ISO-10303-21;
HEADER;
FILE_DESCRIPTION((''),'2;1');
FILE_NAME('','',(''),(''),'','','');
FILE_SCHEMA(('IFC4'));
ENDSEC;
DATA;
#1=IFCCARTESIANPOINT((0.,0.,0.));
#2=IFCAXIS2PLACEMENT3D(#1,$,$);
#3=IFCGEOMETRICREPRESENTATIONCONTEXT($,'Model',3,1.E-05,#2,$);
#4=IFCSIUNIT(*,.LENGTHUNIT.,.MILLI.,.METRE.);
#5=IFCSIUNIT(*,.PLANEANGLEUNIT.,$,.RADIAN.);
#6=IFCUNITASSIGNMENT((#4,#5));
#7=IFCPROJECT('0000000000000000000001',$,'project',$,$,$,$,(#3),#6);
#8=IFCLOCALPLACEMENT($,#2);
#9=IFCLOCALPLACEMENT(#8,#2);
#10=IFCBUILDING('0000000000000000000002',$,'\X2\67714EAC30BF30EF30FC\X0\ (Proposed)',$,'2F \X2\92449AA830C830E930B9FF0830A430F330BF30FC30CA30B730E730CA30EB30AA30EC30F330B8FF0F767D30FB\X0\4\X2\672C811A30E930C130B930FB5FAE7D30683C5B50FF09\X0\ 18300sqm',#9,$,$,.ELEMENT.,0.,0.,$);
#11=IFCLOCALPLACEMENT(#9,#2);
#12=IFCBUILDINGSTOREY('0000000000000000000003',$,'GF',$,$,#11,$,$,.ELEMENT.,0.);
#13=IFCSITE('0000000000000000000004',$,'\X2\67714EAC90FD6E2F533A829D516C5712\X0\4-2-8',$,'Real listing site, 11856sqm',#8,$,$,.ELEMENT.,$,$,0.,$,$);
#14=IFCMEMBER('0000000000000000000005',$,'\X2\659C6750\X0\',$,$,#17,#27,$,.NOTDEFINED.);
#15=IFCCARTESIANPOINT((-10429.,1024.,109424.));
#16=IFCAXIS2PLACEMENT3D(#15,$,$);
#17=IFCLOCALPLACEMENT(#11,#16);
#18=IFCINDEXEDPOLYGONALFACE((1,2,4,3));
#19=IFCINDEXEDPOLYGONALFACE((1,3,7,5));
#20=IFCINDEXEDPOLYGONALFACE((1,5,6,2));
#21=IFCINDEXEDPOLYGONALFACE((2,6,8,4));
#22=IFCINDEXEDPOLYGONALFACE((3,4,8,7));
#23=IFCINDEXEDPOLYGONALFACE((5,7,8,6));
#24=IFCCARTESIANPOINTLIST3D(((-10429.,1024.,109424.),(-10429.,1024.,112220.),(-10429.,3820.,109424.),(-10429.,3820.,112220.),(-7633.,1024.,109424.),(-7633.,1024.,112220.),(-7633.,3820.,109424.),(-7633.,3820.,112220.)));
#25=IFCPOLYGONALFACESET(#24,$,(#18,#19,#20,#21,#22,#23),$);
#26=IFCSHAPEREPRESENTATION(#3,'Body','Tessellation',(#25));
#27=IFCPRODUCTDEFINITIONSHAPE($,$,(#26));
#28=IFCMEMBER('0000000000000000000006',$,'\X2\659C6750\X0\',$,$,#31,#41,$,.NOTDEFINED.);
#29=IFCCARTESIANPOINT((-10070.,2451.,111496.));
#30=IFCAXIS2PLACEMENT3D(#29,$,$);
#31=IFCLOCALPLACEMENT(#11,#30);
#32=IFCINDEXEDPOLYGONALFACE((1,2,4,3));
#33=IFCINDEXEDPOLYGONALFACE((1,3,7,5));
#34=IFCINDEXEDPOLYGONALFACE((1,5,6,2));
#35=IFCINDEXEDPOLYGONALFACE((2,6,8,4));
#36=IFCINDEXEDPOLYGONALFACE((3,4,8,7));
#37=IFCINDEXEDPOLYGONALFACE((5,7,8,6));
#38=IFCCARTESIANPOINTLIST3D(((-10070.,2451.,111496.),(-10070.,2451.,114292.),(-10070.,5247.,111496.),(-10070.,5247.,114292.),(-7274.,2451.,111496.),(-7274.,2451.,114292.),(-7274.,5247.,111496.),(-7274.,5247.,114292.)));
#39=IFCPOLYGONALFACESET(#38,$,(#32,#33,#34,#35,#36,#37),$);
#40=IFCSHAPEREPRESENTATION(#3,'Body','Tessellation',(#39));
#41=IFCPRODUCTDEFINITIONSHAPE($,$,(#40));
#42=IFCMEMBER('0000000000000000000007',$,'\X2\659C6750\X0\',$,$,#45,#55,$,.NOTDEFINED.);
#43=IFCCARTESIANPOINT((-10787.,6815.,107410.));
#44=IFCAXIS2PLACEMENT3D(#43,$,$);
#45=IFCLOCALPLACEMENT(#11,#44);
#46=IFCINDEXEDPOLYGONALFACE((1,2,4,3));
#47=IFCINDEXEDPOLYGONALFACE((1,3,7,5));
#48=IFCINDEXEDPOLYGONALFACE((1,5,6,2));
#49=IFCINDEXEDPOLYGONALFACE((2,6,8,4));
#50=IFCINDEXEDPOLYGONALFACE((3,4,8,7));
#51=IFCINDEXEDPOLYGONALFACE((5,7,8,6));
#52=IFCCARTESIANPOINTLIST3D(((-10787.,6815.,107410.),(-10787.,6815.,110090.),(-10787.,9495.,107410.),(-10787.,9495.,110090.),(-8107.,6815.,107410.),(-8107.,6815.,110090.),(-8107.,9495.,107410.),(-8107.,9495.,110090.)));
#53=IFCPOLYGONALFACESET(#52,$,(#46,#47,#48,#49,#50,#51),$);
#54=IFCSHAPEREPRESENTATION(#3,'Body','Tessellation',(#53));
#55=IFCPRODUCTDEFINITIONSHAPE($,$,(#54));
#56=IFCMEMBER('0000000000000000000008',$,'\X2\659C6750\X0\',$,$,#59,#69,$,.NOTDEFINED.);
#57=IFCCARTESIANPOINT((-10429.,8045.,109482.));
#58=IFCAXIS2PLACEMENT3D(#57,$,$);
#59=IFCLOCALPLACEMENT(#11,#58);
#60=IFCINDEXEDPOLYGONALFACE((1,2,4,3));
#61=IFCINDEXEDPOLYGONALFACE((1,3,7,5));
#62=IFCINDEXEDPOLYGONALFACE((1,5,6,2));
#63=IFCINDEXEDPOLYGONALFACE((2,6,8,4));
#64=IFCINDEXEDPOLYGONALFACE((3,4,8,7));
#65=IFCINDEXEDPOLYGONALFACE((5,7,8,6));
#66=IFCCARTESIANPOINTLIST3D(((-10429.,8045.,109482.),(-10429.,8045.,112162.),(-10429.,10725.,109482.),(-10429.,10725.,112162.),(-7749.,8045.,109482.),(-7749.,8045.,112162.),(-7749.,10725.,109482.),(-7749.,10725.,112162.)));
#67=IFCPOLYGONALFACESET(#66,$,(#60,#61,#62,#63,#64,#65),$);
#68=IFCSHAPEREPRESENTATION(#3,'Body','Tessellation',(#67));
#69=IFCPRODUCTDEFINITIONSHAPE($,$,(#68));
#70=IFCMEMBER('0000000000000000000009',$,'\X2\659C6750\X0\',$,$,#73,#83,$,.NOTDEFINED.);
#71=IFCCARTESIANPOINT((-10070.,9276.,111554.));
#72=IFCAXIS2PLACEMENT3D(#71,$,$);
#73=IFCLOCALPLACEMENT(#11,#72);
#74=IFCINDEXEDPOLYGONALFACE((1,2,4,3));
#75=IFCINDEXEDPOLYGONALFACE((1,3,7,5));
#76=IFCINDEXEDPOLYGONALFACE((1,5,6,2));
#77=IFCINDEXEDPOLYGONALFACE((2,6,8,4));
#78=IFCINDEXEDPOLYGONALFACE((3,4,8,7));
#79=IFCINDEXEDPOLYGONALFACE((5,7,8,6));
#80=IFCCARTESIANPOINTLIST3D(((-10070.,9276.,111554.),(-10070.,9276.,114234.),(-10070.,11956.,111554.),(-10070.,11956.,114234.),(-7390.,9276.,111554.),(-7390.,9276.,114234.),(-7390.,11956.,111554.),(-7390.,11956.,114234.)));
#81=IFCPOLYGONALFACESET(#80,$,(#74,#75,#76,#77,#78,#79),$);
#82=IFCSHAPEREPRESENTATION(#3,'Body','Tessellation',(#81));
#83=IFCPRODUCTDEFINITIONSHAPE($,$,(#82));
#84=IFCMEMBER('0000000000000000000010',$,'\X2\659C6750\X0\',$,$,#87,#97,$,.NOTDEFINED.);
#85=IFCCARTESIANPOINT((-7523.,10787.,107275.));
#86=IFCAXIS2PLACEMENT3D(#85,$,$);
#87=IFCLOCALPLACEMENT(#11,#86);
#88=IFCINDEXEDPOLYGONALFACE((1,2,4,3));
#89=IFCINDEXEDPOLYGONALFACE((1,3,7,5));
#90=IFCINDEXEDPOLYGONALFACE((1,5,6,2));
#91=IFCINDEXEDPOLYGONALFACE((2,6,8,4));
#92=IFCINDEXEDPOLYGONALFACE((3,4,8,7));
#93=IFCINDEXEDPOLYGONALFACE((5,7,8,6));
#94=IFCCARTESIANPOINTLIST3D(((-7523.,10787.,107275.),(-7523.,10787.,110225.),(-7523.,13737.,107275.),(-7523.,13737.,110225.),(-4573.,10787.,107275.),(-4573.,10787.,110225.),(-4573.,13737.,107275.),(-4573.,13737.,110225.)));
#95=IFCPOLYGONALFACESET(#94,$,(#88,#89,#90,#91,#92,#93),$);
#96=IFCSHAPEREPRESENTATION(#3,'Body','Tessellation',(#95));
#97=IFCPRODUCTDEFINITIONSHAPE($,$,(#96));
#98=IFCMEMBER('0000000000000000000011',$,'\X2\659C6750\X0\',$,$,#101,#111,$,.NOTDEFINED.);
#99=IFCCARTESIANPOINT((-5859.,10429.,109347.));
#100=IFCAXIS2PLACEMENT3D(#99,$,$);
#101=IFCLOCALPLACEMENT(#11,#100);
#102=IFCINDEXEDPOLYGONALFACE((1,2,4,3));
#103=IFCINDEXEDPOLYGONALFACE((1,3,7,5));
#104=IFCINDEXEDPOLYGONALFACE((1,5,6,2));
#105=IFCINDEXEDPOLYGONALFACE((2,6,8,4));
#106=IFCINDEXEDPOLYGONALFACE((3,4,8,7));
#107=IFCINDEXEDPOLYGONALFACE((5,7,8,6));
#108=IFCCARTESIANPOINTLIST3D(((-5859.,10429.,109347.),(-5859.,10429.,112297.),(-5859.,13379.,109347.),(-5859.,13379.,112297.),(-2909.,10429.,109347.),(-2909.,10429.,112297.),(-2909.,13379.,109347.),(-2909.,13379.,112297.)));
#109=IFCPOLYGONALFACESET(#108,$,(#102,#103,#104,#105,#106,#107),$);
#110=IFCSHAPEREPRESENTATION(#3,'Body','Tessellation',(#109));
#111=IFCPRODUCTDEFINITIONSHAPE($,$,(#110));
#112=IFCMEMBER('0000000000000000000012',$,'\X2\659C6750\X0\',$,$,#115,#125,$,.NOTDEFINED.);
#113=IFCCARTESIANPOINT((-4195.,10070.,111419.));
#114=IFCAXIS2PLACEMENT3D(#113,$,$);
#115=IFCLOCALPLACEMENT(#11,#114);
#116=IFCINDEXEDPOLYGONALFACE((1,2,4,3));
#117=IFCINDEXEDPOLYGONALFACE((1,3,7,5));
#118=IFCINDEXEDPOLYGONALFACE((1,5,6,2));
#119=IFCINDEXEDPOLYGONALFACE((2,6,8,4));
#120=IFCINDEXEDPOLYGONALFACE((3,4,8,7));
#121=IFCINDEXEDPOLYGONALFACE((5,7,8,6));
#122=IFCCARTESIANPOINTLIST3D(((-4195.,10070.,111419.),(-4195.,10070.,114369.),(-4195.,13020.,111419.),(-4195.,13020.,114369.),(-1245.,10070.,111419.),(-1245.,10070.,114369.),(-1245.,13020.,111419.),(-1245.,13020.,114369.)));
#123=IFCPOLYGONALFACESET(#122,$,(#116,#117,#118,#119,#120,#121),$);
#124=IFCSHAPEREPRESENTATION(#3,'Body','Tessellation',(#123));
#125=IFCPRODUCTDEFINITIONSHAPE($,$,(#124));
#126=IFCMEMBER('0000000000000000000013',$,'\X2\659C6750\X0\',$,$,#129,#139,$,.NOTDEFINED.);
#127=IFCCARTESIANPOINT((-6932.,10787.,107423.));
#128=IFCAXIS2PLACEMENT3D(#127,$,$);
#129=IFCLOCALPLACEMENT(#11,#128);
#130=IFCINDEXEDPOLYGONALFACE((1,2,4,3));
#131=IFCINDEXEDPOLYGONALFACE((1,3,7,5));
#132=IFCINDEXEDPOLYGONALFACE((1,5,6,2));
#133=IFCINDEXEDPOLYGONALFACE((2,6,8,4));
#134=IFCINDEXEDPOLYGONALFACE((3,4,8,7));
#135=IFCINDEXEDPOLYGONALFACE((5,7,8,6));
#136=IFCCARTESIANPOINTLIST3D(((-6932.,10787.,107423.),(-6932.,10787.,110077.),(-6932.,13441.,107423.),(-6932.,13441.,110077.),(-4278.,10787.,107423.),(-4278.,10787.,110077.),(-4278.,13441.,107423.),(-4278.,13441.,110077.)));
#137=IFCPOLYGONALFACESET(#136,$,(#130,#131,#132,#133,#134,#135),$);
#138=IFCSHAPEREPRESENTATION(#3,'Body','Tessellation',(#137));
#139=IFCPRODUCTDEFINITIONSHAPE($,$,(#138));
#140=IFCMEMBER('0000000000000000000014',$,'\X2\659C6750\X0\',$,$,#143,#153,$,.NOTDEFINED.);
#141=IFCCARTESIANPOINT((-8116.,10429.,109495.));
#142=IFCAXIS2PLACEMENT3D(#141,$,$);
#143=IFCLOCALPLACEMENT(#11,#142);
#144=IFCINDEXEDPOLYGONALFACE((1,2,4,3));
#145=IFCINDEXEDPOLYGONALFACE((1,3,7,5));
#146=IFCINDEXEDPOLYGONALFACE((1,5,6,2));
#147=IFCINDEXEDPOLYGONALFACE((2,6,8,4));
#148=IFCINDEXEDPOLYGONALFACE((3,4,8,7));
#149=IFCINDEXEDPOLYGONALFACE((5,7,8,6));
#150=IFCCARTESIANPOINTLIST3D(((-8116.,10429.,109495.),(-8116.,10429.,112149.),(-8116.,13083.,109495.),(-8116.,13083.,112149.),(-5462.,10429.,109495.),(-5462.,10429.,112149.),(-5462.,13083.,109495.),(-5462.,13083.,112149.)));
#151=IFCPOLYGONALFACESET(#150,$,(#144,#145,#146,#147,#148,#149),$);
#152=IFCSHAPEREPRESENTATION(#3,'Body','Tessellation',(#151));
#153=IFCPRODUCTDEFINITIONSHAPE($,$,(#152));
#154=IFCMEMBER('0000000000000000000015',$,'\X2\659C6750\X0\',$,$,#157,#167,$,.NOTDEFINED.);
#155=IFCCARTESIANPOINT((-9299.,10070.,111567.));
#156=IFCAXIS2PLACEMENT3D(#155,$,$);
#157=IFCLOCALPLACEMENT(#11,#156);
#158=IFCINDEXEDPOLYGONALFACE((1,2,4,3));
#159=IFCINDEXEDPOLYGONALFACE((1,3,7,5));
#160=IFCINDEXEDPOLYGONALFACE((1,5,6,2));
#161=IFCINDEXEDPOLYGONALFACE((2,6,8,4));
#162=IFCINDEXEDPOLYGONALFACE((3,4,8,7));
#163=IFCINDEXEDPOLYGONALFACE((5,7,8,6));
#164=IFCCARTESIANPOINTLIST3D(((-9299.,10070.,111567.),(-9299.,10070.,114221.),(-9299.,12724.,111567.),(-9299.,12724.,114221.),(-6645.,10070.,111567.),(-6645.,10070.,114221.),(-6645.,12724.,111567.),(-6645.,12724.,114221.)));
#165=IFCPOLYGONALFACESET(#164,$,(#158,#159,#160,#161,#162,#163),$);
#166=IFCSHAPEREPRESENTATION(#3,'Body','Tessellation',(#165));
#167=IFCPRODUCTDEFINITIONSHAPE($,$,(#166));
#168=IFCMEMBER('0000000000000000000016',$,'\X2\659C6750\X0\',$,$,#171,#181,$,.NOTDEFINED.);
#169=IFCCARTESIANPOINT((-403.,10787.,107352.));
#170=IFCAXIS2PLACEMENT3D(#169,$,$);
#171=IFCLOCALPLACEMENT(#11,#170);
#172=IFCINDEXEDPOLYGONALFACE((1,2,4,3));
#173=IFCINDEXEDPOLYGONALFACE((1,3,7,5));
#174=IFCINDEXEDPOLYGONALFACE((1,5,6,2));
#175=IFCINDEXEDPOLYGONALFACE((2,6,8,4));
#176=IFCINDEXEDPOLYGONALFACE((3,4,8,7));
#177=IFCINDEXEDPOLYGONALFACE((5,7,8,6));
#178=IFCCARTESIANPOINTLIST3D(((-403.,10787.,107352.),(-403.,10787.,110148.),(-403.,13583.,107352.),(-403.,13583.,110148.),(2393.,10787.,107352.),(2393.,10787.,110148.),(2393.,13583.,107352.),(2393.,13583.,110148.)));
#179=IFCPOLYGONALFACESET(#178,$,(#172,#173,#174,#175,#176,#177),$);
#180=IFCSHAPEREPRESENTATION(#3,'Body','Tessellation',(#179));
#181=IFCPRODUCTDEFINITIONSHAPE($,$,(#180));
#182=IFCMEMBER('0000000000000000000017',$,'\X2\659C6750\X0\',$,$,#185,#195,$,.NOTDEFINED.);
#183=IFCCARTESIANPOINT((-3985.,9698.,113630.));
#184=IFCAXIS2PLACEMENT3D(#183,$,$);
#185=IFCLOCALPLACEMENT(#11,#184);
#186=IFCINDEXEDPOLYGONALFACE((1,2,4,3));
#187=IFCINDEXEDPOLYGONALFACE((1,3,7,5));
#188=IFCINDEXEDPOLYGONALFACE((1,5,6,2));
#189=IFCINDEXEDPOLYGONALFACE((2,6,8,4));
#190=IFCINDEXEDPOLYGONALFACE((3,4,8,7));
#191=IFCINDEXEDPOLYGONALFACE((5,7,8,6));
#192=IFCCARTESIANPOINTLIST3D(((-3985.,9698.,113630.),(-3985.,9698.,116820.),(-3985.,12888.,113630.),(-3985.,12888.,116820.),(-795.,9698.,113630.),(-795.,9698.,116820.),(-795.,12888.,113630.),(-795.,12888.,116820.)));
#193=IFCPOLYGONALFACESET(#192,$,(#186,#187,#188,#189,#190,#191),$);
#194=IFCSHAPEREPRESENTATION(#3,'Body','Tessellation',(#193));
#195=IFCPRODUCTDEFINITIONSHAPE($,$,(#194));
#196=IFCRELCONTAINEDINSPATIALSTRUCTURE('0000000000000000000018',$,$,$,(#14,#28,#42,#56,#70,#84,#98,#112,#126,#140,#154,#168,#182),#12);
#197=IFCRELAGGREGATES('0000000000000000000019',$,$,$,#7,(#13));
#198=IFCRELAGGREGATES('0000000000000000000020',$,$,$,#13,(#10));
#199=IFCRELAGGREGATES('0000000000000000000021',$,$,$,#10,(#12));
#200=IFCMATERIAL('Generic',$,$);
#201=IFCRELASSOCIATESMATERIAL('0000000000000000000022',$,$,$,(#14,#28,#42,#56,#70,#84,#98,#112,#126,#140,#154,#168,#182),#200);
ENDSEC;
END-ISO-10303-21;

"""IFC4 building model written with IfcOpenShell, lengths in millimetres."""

from ifc_helpers import new_model, si_unit, frame, frame_2d, origin, place, context, project, spatial, rectangle, extrude, material, element, save


model = new_model("IFC4")

# Units and contexts
model_context = context("Model", 3, precision=1e-05, world=origin())
ifc_project = project(units=[si_unit("LENGTHUNIT", "METRE", prefix="MILLI"), si_unit("PLANEANGLEUNIT", "RADIAN")], contexts=[model_context])

# Site, building, storey
site_placement = place(None, origin())
site = spatial("IfcSite", under=ifc_project, at=site_placement, Name="東京都港区芝公園4-2-8", ObjectType="Real listing site, 11856sqm", CompositionType="ELEMENT", RefElevation=0.0)
building_placement = place(site_placement, origin())
building = spatial("IfcBuilding", under=site, at=building_placement, Name="東京タワー (Proposed)", ObjectType="2F 鉄骨トラス（インターナショナルオレンジ／白・4本脚ラチス・微細格子） 18300sqm", CompositionType="ELEMENT", ElevationOfRefHeight=0.0, ElevationOfTerrain=0.0)
storey_placement = place(building_placement, origin())
storey = spatial("IfcBuildingStorey", under=building, at=storey_placement, Name="GF", CompositionType="ELEMENT", Elevation=0.0)

# Members
ifc_material = material(Name="Generic")
member_1_placement = place(storey_placement, frame((-10429.0, 1024.0, 109424.0)))
element("IfcMember", 1, at=member_1_placement, inside=storey, material=ifc_material, Name="斜材", PredefinedType="NOTDEFINED", context=model_context, shape_type="SweptSolid", body=[
    extrude(rectangle(XDim=2796.0, YDim=2796.0, at=frame_2d((1398.0, 1398.0))), frame((-10429.0, 1024.0, 109424.0)), (0.0, 0.0, 1.0), 2796.0),
])
member_2_placement = place(storey_placement, frame((-10070.0, 2451.0, 111496.0)))
element("IfcMember", 2, at=member_2_placement, inside=storey, material=ifc_material, Name="斜材", PredefinedType="NOTDEFINED", context=model_context, shape_type="SweptSolid", body=[
    extrude(rectangle(XDim=2796.0, YDim=2796.0, at=frame_2d((1398.0, 1398.0))), frame((-10070.0, 2451.0, 111496.0)), (0.0, 0.0, 1.0), 2796.0),
])
member_3_placement = place(storey_placement, frame((-10787.0, 6815.0, 107410.0)))
element("IfcMember", 3, at=member_3_placement, inside=storey, material=ifc_material, Name="斜材", PredefinedType="NOTDEFINED", context=model_context, shape_type="SweptSolid", body=[
    extrude(rectangle(XDim=2680.0, YDim=2680.0, at=frame_2d((1340.0, 1340.0))), frame((-10787.0, 6815.0, 107410.0)), (0.0, 0.0, 1.0), 2680.0),
])
member_4_placement = place(storey_placement, frame((-10429.0, 8045.0, 109482.0)))
element("IfcMember", 4, at=member_4_placement, inside=storey, material=ifc_material, Name="斜材", PredefinedType="NOTDEFINED", context=model_context, shape_type="SweptSolid", body=[
    extrude(rectangle(XDim=2680.0, YDim=2680.0, at=frame_2d((1340.0, 1340.0))), frame((-10429.0, 8045.0, 109482.0)), (0.0, 0.0, 1.0), 2680.0),
])
member_5_placement = place(storey_placement, frame((-10070.0, 9276.0, 111554.0)))
element("IfcMember", 5, at=member_5_placement, inside=storey, material=ifc_material, Name="斜材", PredefinedType="NOTDEFINED", context=model_context, shape_type="SweptSolid", body=[
    extrude(rectangle(XDim=2680.0, YDim=2680.0, at=frame_2d((1340.0, 1340.0))), frame((-10070.0, 9276.0, 111554.0)), (0.0, 0.0, 1.0), 2680.0),
])
member_6_placement = place(storey_placement, frame((-7523.0, 10787.0, 107275.0)))
element("IfcMember", 6, at=member_6_placement, inside=storey, material=ifc_material, Name="斜材", PredefinedType="NOTDEFINED", context=model_context, shape_type="SweptSolid", body=[
    extrude(rectangle(XDim=2950.0, YDim=2950.0, at=frame_2d((1475.0, 1475.0))), frame((-7523.0, 10787.0, 107275.0)), (0.0, 0.0, 1.0), 2950.0),
])
member_7_placement = place(storey_placement, frame((-5859.0, 10429.0, 109347.0)))
element("IfcMember", 7, at=member_7_placement, inside=storey, material=ifc_material, Name="斜材", PredefinedType="NOTDEFINED", context=model_context, shape_type="SweptSolid", body=[
    extrude(rectangle(XDim=2950.0, YDim=2950.0, at=frame_2d((1475.0, 1475.0))), frame((-5859.0, 10429.0, 109347.0)), (0.0, 0.0, 1.0), 2950.0),
])
member_8_placement = place(storey_placement, frame((-4195.0, 10070.0, 111419.0)))
element("IfcMember", 8, at=member_8_placement, inside=storey, material=ifc_material, Name="斜材", PredefinedType="NOTDEFINED", context=model_context, shape_type="SweptSolid", body=[
    extrude(rectangle(XDim=2950.0, YDim=2950.0, at=frame_2d((1475.0, 1475.0))), frame((-4195.0, 10070.0, 111419.0)), (0.0, 0.0, 1.0), 2950.0),
])
member_9_placement = place(storey_placement, frame((-6932.0, 10787.0, 107423.0)))
element("IfcMember", 9, at=member_9_placement, inside=storey, material=ifc_material, Name="斜材", PredefinedType="NOTDEFINED", context=model_context, shape_type="SweptSolid", body=[
    extrude(rectangle(XDim=2654.0, YDim=2654.0, at=frame_2d((1327.0, 1327.0))), frame((-6932.0, 10787.0, 107423.0)), (0.0, 0.0, 1.0), 2654.0),
])
member_10_placement = place(storey_placement, frame((-8116.0, 10429.0, 109495.0)))
element("IfcMember", 10, at=member_10_placement, inside=storey, material=ifc_material, Name="斜材", PredefinedType="NOTDEFINED", context=model_context, shape_type="SweptSolid", body=[
    extrude(rectangle(XDim=2654.0, YDim=2654.0, at=frame_2d((1327.0, 1327.0))), frame((-8116.0, 10429.0, 109495.0)), (0.0, 0.0, 1.0), 2654.0),
])
member_11_placement = place(storey_placement, frame((-9299.0, 10070.0, 111567.0)))
element("IfcMember", 11, at=member_11_placement, inside=storey, material=ifc_material, Name="斜材", PredefinedType="NOTDEFINED", context=model_context, shape_type="SweptSolid", body=[
    extrude(rectangle(XDim=2654.0, YDim=2654.0, at=frame_2d((1327.0, 1327.0))), frame((-9299.0, 10070.0, 111567.0)), (0.0, 0.0, 1.0), 2654.0),
])
member_12_placement = place(storey_placement, frame((-403.0, 10787.0, 107352.0)))
element("IfcMember", 12, at=member_12_placement, inside=storey, material=ifc_material, Name="斜材", PredefinedType="NOTDEFINED", context=model_context, shape_type="SweptSolid", body=[
    extrude(rectangle(XDim=2796.0, YDim=2796.0, at=frame_2d((1398.0, 1398.0))), frame((-403.0, 10787.0, 107352.0)), (0.0, 0.0, 1.0), 2796.0),
])
member_13_placement = place(storey_placement, frame((-3985.0, 9698.0, 113630.0)))
element("IfcMember", 13, at=member_13_placement, inside=storey, material=ifc_material, Name="斜材", PredefinedType="NOTDEFINED", context=model_context, shape_type="SweptSolid", body=[
    extrude(rectangle(XDim=3190.0, YDim=3190.0, at=frame_2d((1595.0, 1595.0))), frame((-3985.0, 9698.0, 113630.0)), (0.0, 0.0, 1.0), 3190.0),
])

save(model, "model.ifc")
